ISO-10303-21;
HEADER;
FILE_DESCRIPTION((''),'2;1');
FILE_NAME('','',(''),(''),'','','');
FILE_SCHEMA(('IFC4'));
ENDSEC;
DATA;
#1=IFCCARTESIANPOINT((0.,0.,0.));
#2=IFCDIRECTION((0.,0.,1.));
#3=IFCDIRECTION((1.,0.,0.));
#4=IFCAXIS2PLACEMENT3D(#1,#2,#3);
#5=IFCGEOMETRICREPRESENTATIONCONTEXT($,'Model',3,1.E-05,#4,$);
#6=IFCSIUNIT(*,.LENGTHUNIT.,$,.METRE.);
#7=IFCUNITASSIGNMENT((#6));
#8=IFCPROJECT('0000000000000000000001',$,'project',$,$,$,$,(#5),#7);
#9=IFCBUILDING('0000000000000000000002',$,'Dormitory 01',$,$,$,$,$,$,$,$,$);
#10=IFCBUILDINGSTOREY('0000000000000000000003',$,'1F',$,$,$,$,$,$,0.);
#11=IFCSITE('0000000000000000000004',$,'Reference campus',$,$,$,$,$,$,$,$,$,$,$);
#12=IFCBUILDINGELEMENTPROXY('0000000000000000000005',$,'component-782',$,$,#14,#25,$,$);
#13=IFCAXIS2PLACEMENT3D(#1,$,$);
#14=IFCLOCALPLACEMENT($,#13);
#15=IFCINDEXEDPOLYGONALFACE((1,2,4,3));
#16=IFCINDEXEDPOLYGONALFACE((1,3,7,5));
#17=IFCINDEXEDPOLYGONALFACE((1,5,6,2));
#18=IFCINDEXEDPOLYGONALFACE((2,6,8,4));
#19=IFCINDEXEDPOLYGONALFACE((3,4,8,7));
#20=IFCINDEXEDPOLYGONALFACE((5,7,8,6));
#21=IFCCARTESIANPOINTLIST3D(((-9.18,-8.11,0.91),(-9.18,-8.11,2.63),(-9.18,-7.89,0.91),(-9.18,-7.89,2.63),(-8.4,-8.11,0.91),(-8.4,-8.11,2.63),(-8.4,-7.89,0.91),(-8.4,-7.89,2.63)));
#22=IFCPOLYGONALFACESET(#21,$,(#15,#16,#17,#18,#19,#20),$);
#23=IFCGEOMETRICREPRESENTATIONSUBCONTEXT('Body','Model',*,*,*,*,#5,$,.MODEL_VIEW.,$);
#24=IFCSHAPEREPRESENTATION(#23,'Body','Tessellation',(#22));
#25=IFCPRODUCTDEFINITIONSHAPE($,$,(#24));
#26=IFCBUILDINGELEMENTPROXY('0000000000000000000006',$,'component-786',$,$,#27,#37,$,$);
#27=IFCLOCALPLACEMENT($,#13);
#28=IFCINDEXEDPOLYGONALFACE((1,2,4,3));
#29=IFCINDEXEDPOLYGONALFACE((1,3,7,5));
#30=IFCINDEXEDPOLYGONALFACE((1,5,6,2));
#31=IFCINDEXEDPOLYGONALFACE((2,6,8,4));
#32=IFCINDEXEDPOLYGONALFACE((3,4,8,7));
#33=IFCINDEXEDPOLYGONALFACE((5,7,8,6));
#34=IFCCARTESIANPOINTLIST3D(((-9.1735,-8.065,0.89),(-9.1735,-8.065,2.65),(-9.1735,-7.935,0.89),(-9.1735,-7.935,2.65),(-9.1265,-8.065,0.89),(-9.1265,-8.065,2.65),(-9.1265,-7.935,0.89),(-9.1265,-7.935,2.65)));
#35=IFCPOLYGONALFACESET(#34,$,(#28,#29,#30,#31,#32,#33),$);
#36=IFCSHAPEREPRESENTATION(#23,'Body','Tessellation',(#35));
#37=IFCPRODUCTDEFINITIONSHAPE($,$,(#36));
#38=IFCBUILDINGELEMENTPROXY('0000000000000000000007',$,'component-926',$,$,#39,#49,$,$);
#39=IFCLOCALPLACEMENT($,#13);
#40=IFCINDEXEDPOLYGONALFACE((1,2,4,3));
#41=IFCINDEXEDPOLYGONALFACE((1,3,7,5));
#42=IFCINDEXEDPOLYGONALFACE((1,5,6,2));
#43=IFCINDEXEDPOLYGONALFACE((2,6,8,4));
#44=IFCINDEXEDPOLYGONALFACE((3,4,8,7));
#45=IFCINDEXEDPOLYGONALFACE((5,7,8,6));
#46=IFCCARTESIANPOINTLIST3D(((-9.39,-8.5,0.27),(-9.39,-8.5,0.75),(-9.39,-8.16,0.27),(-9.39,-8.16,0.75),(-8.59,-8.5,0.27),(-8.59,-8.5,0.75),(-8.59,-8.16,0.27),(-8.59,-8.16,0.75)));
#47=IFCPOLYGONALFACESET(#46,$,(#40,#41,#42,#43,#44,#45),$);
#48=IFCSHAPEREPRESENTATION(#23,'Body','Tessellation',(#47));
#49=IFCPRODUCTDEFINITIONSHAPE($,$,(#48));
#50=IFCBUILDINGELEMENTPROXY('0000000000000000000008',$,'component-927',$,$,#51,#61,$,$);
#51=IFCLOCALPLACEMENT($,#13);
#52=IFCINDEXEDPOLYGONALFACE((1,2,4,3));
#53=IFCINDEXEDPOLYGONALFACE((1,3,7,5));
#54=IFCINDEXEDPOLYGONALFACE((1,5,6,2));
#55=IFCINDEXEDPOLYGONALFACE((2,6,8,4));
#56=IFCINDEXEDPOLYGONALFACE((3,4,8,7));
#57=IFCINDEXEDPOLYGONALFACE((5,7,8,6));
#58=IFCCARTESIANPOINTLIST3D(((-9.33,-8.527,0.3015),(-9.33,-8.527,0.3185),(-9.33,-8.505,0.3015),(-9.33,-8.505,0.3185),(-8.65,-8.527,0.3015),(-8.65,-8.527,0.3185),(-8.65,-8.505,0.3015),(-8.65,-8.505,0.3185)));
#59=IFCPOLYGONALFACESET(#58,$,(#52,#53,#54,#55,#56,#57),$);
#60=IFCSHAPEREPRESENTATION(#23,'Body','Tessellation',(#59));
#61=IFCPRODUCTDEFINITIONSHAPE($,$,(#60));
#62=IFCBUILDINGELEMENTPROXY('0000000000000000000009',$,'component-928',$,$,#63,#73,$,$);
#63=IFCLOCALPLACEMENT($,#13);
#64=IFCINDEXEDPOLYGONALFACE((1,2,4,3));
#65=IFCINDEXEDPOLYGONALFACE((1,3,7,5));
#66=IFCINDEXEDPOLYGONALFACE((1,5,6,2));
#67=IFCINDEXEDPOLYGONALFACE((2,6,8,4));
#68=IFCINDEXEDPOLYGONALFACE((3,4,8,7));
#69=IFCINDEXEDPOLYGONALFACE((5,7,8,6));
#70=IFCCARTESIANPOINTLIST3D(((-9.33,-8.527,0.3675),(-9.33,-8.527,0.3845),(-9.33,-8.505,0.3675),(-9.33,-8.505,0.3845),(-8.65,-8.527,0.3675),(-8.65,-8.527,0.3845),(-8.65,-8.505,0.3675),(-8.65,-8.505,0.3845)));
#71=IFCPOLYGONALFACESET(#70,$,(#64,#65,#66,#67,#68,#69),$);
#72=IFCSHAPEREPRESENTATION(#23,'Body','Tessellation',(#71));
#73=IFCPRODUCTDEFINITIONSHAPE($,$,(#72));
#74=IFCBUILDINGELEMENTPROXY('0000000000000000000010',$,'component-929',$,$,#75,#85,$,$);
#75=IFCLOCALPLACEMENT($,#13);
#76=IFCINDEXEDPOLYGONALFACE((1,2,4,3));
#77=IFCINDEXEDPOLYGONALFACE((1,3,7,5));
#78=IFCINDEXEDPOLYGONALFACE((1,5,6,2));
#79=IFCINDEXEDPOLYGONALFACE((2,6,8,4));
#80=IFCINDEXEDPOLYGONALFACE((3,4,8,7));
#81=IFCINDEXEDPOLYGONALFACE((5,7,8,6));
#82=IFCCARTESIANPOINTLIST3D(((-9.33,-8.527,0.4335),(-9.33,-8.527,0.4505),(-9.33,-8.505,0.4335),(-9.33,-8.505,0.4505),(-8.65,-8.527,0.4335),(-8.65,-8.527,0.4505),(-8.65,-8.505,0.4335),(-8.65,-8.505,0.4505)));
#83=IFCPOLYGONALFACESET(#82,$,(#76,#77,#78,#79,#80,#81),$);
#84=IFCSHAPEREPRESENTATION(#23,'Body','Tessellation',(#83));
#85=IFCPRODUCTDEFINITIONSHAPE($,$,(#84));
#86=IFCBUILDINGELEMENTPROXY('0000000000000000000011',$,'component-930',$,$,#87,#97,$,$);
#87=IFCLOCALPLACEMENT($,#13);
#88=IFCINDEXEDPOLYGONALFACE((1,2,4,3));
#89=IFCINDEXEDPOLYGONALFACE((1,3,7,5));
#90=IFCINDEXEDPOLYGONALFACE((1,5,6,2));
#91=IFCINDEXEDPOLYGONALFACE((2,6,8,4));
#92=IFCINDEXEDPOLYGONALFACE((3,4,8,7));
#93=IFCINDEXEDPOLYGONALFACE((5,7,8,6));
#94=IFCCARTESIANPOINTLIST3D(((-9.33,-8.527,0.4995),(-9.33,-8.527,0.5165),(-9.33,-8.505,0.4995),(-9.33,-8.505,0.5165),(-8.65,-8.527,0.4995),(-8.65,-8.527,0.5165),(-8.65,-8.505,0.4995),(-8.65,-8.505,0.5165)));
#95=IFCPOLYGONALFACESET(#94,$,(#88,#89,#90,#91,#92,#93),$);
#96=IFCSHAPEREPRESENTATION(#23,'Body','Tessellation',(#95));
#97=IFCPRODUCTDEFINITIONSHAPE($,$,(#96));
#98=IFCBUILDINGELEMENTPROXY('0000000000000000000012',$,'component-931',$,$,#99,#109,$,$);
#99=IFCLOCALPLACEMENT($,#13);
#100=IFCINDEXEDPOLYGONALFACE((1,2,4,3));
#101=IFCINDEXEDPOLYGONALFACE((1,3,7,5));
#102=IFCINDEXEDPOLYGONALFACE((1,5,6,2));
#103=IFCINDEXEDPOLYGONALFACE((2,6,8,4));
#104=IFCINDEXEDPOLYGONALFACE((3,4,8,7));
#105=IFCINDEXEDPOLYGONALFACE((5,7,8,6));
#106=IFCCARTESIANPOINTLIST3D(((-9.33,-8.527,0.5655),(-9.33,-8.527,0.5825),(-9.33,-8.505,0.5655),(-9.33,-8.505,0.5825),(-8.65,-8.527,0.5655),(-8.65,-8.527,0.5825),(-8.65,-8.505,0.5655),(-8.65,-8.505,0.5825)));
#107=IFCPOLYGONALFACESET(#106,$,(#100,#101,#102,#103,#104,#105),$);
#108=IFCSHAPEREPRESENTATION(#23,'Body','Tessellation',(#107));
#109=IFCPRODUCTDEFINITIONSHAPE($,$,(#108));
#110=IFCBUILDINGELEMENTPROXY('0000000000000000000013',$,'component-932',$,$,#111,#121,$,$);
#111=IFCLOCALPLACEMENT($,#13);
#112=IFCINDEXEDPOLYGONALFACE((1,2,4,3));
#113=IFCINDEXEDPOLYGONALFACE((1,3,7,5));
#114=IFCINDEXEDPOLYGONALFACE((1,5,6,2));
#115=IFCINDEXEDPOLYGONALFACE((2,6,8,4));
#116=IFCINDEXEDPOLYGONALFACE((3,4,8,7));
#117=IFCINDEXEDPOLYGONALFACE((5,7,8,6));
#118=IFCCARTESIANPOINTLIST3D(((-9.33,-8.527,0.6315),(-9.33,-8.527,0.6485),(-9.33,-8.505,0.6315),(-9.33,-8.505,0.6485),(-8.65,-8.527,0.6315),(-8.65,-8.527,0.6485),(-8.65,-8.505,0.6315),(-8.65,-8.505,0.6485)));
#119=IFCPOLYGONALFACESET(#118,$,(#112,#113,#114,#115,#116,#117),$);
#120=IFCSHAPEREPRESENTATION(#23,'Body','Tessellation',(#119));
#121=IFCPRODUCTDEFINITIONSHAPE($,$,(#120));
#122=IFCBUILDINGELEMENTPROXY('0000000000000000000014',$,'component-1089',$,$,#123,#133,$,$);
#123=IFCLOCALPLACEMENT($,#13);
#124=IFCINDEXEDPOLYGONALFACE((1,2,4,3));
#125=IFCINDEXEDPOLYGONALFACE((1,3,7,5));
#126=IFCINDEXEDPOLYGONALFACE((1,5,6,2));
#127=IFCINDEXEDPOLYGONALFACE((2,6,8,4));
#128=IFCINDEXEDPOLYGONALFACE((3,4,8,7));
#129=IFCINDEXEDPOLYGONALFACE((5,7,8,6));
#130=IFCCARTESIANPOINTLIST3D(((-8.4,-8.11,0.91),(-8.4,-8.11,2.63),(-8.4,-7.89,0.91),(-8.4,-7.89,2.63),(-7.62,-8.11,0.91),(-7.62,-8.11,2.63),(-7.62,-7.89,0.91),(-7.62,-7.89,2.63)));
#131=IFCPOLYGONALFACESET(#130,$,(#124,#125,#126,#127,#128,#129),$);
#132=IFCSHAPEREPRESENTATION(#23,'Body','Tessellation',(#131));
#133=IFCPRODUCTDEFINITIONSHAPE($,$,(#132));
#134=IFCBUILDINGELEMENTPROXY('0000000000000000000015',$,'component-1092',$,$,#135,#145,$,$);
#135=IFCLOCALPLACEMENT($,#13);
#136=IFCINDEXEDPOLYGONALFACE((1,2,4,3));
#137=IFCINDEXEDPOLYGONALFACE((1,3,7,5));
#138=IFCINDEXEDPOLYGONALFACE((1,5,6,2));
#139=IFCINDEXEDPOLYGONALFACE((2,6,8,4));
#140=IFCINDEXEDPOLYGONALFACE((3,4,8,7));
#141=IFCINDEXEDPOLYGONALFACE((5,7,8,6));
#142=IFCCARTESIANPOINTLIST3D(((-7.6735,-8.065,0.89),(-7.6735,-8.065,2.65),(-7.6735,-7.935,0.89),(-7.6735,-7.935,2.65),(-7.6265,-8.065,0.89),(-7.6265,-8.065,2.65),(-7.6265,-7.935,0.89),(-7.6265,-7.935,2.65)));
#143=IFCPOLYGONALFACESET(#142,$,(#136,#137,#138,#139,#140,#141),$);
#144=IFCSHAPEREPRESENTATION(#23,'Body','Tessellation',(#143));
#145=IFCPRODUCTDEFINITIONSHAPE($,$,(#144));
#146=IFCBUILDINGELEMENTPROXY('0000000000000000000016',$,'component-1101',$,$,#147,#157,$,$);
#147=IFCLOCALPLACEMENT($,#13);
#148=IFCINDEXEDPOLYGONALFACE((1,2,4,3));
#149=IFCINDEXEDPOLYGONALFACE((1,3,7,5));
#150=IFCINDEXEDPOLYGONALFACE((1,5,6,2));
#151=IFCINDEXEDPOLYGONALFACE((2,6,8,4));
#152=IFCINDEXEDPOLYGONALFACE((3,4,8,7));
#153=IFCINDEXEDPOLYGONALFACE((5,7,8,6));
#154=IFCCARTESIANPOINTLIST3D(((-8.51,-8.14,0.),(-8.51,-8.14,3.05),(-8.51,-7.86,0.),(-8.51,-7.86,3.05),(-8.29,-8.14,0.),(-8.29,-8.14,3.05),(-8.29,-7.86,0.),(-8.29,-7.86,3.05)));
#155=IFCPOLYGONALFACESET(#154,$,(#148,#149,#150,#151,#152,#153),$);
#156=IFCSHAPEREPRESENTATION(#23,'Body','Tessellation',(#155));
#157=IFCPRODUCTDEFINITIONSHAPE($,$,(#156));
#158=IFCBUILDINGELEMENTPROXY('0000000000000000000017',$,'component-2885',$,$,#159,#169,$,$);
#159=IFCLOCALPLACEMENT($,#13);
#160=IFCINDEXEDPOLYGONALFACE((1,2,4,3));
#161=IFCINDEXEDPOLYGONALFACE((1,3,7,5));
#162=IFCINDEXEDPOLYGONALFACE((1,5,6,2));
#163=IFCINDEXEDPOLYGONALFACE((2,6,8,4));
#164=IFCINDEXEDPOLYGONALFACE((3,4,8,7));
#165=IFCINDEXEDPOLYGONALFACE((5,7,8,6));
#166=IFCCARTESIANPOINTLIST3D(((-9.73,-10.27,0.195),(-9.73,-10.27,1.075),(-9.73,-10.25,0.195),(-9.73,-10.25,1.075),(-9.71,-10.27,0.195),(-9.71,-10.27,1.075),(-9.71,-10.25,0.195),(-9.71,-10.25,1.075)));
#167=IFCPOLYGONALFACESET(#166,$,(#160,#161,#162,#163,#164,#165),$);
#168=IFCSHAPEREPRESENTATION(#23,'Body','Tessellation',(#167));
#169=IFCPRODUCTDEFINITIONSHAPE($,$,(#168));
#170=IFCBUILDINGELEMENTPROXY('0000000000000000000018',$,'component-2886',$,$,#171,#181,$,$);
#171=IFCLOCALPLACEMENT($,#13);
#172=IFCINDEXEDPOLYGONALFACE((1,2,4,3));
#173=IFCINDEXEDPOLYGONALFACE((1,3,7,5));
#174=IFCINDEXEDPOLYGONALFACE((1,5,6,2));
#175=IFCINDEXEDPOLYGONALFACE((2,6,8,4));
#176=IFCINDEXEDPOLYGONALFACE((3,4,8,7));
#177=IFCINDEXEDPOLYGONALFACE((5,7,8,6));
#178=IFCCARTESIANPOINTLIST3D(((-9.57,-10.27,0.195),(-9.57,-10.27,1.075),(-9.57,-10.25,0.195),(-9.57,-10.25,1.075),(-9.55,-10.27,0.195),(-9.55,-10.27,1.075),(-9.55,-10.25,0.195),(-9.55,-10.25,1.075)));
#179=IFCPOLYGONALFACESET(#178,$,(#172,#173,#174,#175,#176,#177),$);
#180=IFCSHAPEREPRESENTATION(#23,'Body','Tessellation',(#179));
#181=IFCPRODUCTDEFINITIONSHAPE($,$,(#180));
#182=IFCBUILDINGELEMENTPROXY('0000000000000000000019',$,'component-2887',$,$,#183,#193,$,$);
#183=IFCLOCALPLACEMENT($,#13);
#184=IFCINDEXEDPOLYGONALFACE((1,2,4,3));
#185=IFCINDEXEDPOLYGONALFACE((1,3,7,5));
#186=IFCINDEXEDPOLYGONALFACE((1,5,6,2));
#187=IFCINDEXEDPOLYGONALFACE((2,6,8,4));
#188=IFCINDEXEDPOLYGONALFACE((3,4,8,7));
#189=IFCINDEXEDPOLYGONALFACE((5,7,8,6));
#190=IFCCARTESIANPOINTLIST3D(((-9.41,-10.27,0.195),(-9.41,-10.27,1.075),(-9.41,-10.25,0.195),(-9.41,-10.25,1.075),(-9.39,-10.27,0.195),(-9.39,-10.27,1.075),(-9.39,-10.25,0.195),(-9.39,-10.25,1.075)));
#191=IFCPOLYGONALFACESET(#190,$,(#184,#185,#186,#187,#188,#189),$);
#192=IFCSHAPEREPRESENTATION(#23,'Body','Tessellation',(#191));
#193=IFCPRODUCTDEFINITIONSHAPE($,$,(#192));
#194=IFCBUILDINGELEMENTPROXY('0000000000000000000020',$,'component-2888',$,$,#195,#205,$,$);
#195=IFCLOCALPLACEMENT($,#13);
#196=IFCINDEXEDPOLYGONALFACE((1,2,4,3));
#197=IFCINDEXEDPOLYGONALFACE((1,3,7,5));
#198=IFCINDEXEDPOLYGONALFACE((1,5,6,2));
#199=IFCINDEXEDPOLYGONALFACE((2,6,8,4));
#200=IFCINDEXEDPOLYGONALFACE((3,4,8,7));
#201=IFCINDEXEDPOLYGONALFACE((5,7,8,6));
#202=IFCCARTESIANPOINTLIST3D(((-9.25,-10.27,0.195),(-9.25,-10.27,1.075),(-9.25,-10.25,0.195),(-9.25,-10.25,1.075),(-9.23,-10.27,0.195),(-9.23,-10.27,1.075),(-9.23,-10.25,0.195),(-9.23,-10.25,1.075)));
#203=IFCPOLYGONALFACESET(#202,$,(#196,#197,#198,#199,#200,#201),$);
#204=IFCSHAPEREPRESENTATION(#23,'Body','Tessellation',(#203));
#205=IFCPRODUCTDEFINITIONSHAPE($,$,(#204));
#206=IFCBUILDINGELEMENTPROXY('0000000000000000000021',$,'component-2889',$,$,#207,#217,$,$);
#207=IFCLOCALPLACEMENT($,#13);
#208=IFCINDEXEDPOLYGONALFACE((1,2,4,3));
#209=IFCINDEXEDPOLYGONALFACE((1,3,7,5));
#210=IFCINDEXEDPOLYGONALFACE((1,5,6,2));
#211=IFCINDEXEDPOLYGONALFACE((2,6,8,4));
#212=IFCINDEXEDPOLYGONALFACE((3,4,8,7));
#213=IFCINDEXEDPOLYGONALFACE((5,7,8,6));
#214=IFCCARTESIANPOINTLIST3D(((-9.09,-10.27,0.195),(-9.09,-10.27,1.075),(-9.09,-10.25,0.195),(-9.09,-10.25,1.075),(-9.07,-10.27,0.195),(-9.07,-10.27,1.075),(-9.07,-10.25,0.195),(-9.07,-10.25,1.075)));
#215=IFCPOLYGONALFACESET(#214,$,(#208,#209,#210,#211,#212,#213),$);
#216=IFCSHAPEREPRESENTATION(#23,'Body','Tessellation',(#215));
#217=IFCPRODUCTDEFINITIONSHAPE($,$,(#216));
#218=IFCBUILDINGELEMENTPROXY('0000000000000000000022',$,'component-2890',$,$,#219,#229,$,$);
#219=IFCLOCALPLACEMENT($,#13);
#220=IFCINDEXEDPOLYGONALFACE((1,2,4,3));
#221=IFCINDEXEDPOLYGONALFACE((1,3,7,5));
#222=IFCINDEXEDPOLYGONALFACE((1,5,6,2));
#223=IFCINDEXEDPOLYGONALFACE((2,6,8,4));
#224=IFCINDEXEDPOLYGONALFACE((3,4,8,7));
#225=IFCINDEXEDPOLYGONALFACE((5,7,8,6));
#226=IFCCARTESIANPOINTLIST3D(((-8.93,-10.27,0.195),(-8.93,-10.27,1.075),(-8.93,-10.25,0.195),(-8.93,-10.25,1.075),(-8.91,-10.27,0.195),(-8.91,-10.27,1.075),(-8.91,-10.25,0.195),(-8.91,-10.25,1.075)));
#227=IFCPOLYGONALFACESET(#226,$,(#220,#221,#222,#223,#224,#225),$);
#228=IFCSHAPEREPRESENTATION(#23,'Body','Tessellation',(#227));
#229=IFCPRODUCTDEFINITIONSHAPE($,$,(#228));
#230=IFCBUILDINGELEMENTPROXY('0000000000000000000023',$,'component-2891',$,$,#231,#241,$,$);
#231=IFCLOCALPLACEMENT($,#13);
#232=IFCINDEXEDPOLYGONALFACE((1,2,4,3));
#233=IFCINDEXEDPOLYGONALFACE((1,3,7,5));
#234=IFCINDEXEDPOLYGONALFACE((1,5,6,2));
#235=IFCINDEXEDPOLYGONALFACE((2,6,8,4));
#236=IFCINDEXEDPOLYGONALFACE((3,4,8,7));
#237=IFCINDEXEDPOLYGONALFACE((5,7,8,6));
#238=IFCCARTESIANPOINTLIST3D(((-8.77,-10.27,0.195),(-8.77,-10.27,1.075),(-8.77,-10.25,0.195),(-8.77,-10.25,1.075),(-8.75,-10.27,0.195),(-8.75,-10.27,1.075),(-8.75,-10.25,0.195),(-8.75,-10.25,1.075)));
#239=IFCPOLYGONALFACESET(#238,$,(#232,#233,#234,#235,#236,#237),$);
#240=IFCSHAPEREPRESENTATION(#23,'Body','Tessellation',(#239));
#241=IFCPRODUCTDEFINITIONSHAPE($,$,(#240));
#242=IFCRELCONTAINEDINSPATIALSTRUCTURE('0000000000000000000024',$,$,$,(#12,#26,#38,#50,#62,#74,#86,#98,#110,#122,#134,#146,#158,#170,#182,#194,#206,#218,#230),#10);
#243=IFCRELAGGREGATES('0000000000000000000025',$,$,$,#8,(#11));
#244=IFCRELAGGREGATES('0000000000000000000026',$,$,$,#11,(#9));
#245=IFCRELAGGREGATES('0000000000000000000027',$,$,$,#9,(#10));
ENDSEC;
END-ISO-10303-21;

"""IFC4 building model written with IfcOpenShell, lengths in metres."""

from ifc_helpers import new_model, si_unit, frame, origin, origin_with_axes, origin_2d, place, context, subcontext, project, spatial, rectangle, extrude, element, save


model = new_model("IFC4")

# Units and contexts
model_context = context("Model", 3, precision=1e-05, world=origin_with_axes())
body_context = subcontext(model_context, "Body", "Model", "MODEL_VIEW")
ifc_project = project(units=[si_unit("LENGTHUNIT", "METRE")], contexts=[model_context])

# Site, building, storey
site = spatial("IfcSite", under=ifc_project, Name="Reference campus")
building = spatial("IfcBuilding", under=site, Name="Dormitory 01")
storey = spatial("IfcBuildingStorey", under=building, Name="1F", Elevation=0.0)

# Building element proxies
proxy_1_placement = place(None, frame((-8.79, -8.0, 0.91), z_axis=(0.0, 0.0, 1.0), x_axis=(1.0, 0.0, 0.0)))
element("IfcBuildingElementProxy", 1, at=proxy_1_placement, inside=storey, Name="component-782", context=body_context, shape_type="SweptSolid", body=[
    extrude(rectangle(XDim=0.78, YDim=0.22, at=origin_2d()), origin(), (0.0, 0.0, 1.0), 1.72),
])
proxy_2_placement = place(None, frame((-9.15, -8.0, 0.89), z_axis=(0.0, 0.0, 1.0), x_axis=(1.0, 0.0, 0.0)))
element("IfcBuildingElementProxy", 2, at=proxy_2_placement, inside=storey, Name="component-786", context=body_context, shape_type="SweptSolid", body=[
    extrude(rectangle(XDim=0.047, YDim=0.13, at=origin_2d()), origin(), (0.0, 0.0, 1.0), 1.76),
])
proxy_3_placement = place(None, frame((-8.99, -8.33, 0.27), z_axis=(0.0, 0.0, 1.0), x_axis=(1.0, 0.0, 0.0)))
element("IfcBuildingElementProxy", 3, at=proxy_3_placement, inside=storey, Name="component-926", context=body_context, shape_type="SweptSolid", body=[
    extrude(rectangle(XDim=0.8, YDim=0.34, at=origin_2d()), origin(), (0.0, 0.0, 1.0), 0.48),
])
for number, where, z_axis, x_axis, name in (
    (4, (-8.99, -8.516, 0.3015), (0.0, 0.0, 1.0), (1.0, 0.0, 0.0), "component-927"),
    (5, (-8.99, -8.516, 0.3675), (0.0, 0.0, 1.0), (1.0, 0.0, 0.0), "component-928"),
    (6, (-8.99, -8.516, 0.4335), (0.0, 0.0, 1.0), (1.0, 0.0, 0.0), "component-929"),
    (7, (-8.99, -8.516, 0.4995), (0.0, 0.0, 1.0), (1.0, 0.0, 0.0), "component-930"),
    (8, (-8.99, -8.516, 0.5655), (0.0, 0.0, 1.0), (1.0, 0.0, 0.0), "component-931"),
    (9, (-8.99, -8.516, 0.6315), (0.0, 0.0, 1.0), (1.0, 0.0, 0.0), "component-932"),
):
    element("IfcBuildingElementProxy", number, at=place(None, frame(where, z_axis=z_axis, x_axis=x_axis)), inside=storey, Name=name, context=body_context, shape_type="SweptSolid", body=[
        extrude(rectangle(XDim=0.68, YDim=0.022, at=origin_2d()), origin(), (0.0, 0.0, 1.0), 0.017),
    ])
proxy_4_placement = place(None, frame((-8.01, -8.0, 0.91), z_axis=(0.0, 0.0, 1.0), x_axis=(1.0, 0.0, 0.0)))
element("IfcBuildingElementProxy", 10, at=proxy_4_placement, inside=storey, Name="component-1089", context=body_context, shape_type="SweptSolid", body=[
    extrude(rectangle(XDim=0.78, YDim=0.22, at=origin_2d()), origin(), (0.0, 0.0, 1.0), 1.72),
])
proxy_5_placement = place(None, frame((-7.65, -8.0, 0.89), z_axis=(0.0, 0.0, 1.0), x_axis=(1.0, 0.0, 0.0)))
element("IfcBuildingElementProxy", 11, at=proxy_5_placement, inside=storey, Name="component-1092", context=body_context, shape_type="SweptSolid", body=[
    extrude(rectangle(XDim=0.047, YDim=0.13, at=origin_2d()), origin(), (0.0, 0.0, 1.0), 1.76),
])
proxy_6_placement = place(None, frame((-8.4, -8.0, 0.0), z_axis=(0.0, 0.0, 1.0), x_axis=(1.0, 0.0, 0.0)))
element("IfcBuildingElementProxy", 12, at=proxy_6_placement, inside=storey, Name="component-1101", context=body_context, shape_type="SweptSolid", body=[
    extrude(rectangle(XDim=0.22, YDim=0.28, at=origin_2d()), origin(), (0.0, 0.0, 1.0), 3.05),
])
for number, where, z_axis, x_axis, name in (
    (13, (-9.72, -10.26, 0.195), (0.0, 0.0, 1.0), (1.0, 0.0, 0.0), "component-2885"),
    (14, (-9.56, -10.26, 0.195), (0.0, 0.0, 1.0), (1.0, 0.0, 0.0), "component-2886"),
    (15, (-9.4, -10.26, 0.195), (0.0, 0.0, 1.0), (1.0, 0.0, 0.0), "component-2887"),
    (16, (-9.24, -10.26, 0.195), (0.0, 0.0, 1.0), (1.0, 0.0, 0.0), "component-2888"),
    (17, (-9.08, -10.26, 0.195), (0.0, 0.0, 1.0), (1.0, 0.0, 0.0), "component-2889"),
    (18, (-8.92, -10.26, 0.195), (0.0, 0.0, 1.0), (1.0, 0.0, 0.0), "component-2890"),
    (19, (-8.76, -10.26, 0.195), (0.0, 0.0, 1.0), (1.0, 0.0, 0.0), "component-2891"),
):
    element("IfcBuildingElementProxy", number, at=place(None, frame(where, z_axis=z_axis, x_axis=x_axis)), inside=storey, Name=name, context=body_context, shape_type="SweptSolid", body=[
        extrude(rectangle(XDim=0.02, YDim=0.02, at=origin_2d()), origin(), (0.0, 0.0, 1.0), 0.88),
    ])

save(model, "model.ifc")
